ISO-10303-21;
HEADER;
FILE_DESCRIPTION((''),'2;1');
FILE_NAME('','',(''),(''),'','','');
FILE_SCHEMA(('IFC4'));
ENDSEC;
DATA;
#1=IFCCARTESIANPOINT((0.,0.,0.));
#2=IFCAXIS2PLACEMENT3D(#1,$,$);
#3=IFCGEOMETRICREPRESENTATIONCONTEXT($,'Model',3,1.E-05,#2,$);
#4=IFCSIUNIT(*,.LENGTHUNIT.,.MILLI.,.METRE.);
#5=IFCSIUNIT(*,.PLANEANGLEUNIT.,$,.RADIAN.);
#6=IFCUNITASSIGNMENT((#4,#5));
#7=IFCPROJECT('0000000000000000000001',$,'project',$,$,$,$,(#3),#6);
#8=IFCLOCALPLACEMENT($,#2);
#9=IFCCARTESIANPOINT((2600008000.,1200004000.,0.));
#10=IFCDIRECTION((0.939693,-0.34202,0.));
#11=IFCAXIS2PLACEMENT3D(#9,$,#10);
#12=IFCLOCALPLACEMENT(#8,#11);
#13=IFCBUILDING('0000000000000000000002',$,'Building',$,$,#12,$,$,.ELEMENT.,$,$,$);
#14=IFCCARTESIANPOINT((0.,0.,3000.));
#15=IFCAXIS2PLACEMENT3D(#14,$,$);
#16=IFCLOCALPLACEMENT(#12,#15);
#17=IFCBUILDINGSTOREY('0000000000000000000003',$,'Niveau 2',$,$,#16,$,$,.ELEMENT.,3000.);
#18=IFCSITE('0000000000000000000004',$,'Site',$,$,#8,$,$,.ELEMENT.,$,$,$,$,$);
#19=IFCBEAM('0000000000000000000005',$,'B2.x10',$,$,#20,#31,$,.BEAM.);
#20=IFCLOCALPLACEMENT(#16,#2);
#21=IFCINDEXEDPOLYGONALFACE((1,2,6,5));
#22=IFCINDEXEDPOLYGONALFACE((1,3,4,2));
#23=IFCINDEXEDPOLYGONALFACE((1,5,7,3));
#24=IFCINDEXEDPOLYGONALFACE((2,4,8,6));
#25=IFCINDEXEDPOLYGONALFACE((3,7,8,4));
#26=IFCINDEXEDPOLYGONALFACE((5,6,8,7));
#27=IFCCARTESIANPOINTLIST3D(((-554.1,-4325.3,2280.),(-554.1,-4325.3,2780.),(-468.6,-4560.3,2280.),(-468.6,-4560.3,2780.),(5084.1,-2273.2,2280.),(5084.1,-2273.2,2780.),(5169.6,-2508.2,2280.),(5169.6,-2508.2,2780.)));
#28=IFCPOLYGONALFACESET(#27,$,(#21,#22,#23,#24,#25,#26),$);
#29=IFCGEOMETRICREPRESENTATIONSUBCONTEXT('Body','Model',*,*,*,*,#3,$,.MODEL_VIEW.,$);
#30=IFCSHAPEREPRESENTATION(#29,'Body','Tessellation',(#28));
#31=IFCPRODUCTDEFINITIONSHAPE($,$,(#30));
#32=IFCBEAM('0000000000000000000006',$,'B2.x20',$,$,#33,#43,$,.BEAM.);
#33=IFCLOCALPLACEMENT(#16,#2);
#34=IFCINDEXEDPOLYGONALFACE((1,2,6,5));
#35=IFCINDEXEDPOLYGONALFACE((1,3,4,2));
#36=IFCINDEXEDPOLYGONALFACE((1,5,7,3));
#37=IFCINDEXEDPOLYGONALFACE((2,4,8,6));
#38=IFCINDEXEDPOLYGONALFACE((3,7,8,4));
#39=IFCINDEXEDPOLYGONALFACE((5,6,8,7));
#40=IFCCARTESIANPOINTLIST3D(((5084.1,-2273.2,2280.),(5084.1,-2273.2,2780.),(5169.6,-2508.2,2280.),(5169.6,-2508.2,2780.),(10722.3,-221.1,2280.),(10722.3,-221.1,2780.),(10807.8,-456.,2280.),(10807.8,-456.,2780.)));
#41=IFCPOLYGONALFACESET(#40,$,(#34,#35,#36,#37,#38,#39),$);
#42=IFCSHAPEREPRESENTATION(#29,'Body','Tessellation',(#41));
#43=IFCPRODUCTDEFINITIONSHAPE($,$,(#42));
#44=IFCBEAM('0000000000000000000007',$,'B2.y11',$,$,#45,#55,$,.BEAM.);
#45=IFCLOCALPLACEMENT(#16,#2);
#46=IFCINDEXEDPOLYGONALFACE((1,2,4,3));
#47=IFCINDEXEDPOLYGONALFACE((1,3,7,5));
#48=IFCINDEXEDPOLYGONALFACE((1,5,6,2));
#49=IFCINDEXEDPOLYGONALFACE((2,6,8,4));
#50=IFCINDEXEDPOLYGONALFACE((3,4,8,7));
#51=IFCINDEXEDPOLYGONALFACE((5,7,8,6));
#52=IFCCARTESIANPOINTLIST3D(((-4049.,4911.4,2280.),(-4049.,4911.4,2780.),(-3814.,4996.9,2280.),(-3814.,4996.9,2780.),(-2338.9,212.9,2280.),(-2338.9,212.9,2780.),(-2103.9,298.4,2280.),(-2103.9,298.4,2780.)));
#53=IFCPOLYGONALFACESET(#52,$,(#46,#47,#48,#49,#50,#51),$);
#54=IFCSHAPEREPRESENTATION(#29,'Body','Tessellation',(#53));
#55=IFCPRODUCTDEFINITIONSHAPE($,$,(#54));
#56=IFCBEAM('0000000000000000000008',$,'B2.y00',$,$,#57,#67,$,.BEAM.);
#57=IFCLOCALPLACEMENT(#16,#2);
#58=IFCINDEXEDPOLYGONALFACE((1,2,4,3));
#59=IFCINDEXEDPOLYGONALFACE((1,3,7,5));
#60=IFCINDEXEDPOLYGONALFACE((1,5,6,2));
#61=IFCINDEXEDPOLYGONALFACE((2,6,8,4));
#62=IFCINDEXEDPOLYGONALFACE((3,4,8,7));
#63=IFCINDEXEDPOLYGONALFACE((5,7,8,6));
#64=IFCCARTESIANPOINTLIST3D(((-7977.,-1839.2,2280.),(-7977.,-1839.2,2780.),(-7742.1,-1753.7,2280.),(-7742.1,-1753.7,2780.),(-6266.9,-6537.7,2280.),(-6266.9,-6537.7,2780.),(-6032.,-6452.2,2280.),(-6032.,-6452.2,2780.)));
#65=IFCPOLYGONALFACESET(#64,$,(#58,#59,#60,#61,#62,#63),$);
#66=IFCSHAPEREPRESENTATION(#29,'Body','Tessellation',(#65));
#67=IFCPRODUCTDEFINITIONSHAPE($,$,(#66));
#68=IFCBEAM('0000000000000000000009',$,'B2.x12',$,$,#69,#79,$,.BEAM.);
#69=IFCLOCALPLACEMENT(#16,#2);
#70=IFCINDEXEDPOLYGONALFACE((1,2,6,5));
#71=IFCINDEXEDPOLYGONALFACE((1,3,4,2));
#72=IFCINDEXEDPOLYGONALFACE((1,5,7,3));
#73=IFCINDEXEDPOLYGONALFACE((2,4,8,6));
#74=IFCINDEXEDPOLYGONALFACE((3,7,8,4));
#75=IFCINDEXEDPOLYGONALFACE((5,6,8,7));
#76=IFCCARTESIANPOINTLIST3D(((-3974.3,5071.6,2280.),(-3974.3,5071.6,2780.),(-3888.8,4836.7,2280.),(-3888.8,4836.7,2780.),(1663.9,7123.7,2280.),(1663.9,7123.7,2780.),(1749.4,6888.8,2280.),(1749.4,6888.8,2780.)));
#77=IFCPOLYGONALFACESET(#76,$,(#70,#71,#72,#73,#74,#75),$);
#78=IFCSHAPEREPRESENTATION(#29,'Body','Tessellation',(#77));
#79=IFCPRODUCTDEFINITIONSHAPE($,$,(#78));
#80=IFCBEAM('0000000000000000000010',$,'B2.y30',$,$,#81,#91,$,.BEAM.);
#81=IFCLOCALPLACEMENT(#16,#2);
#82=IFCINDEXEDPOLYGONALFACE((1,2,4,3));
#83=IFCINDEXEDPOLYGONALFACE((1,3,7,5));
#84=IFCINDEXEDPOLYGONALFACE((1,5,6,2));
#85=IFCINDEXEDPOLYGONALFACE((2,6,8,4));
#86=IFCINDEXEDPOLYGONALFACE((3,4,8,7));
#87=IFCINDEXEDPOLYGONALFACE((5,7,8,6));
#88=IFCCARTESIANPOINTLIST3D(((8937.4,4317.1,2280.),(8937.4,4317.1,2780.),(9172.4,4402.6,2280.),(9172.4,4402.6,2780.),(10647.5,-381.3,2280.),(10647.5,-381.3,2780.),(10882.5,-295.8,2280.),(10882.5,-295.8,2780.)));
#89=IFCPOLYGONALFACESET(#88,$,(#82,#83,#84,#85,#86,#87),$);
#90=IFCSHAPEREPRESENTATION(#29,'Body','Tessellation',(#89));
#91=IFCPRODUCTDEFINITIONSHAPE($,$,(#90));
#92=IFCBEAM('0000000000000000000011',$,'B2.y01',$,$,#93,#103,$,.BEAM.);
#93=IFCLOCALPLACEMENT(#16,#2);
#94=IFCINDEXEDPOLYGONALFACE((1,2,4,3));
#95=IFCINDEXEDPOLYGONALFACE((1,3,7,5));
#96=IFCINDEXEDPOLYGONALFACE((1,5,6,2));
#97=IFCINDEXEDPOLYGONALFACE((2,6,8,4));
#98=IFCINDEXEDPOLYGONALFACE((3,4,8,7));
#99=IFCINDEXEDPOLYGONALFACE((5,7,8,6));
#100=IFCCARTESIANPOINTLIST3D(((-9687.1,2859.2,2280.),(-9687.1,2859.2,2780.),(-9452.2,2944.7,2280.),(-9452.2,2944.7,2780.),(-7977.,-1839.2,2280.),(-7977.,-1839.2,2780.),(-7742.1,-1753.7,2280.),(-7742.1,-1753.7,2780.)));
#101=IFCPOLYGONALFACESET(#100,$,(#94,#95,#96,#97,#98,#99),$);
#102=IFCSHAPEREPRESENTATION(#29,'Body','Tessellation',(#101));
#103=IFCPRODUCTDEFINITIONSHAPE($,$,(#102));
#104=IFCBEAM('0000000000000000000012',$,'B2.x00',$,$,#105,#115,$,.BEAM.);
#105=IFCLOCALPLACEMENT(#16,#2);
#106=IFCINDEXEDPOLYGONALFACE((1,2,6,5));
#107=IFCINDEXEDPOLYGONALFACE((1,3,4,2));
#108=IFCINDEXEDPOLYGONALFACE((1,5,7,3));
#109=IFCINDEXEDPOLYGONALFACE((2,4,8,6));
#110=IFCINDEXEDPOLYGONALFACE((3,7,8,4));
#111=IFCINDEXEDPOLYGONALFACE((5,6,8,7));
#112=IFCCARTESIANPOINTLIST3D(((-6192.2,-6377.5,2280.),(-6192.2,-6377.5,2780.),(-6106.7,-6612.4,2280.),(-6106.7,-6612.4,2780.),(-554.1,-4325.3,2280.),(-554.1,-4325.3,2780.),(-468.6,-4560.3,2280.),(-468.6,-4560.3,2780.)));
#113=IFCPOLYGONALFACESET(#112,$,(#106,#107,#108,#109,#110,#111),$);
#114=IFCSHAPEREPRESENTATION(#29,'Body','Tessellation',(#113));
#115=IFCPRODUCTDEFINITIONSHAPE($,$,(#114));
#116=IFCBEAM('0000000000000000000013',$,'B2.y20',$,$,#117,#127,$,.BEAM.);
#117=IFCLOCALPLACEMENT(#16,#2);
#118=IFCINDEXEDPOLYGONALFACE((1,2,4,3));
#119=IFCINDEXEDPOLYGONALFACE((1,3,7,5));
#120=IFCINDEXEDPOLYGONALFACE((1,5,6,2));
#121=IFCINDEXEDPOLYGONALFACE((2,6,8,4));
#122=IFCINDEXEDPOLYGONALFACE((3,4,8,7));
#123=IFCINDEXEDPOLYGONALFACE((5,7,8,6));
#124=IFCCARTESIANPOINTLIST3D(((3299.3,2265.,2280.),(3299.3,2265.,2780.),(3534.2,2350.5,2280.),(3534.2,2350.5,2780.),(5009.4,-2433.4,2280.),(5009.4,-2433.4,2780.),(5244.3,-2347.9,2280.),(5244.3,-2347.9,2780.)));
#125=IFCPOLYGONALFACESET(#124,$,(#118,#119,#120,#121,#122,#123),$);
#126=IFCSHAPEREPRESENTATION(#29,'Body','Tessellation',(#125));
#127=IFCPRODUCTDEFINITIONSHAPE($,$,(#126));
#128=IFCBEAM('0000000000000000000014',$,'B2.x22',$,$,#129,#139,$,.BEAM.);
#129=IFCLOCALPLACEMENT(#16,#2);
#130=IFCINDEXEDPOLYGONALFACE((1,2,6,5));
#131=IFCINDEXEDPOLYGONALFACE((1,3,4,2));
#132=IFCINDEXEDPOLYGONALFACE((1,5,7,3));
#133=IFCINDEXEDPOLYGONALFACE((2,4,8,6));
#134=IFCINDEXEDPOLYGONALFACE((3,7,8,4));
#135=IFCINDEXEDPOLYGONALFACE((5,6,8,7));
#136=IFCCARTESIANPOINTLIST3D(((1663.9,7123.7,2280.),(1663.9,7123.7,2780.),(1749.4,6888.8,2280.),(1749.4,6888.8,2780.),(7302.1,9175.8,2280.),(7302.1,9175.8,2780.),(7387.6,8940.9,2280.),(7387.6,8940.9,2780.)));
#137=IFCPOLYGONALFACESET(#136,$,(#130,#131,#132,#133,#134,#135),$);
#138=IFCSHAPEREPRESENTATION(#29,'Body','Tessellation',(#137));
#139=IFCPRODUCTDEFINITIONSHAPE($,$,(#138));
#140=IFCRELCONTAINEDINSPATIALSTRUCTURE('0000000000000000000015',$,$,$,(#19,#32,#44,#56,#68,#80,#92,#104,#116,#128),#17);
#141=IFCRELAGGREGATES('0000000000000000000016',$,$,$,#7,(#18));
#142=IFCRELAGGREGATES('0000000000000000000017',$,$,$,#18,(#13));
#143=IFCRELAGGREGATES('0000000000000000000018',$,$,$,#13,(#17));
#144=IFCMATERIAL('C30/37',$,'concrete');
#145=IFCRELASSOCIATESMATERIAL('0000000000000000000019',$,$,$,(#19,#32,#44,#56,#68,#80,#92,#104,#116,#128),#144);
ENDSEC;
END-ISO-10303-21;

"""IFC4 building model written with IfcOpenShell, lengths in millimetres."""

from ifc_helpers import new_model, si_unit, frame, origin, place, context, subcontext, project, spatial, rectangle, extrude, material, element, save


model = new_model("IFC4")

# Units and contexts
model_context = context("Model", 3, precision=1e-05, world=origin())
body_context = subcontext(model_context, "Body", "Model", "MODEL_VIEW")
ifc_project = project(units=[si_unit("LENGTHUNIT", "METRE", prefix="MILLI"), si_unit("PLANEANGLEUNIT", "RADIAN")], contexts=[model_context])

# Site, building, storey
site_placement = place(None, origin())
site = spatial("IfcSite", under=ifc_project, at=site_placement, Name="Site", CompositionType="ELEMENT")
building_placement = place(site_placement, frame((2600008000.0, 1200004000.0, 0.0), x_axis=(0.939693, -0.34202, 0.0)))
building = spatial("IfcBuilding", under=site, at=building_placement, Name="Building", CompositionType="ELEMENT")
storey_placement = place(building_placement, frame((0.0, 0.0, 3000.0)))
storey = spatial("IfcBuildingStorey", under=building, at=storey_placement, Name="Niveau 2", CompositionType="ELEMENT", Elevation=3000.0)

# Shared definitions
ifc_material = material(Name="C30/37", Category="concrete")

# Beams
for number, where, z_axis, x_axis, name in (
    (1, (-511.3, -4442.8, 2530.0), (0.939693, 0.34202, 0.0), (-0.34202, 0.939693, 0.0), "B2.x10"),
    (2, (5126.9, -2390.7, 2530.0), (0.939693, 0.34202, 0.0), (-0.34202, 0.939693, 0.0), "B2.x20"),
):
    element("IfcBeam", number, at=place(storey_placement, frame(where, z_axis=z_axis, x_axis=x_axis)), inside=storey, material=ifc_material, Name=name, PredefinedType="BEAM", context=body_context, shape_type="SweptSolid", body=[
        extrude(rectangle(XDim=250.0, YDim=500.0), origin(), (0.0, 0.0, 1.0), 6000.0),
    ])
for number, where, z_axis, x_axis, name in (
    (3, (-2221.4, 255.7, 2530.0), (-0.34202, 0.939693, 0.0), (-0.939693, -0.34202, 0.0), "B2.y11"),
    (4, (-6149.5, -6494.9, 2530.0), (-0.34202, 0.939693, 0.0), (-0.939693, -0.34202, 0.0), "B2.y00"),
):
    element("IfcBeam", number, at=place(storey_placement, frame(where, z_axis=z_axis, x_axis=x_axis)), inside=storey, material=ifc_material, Name=name, PredefinedType="BEAM", context=body_context, shape_type="SweptSolid", body=[
        extrude(rectangle(XDim=250.0, YDim=500.0), origin(), (0.0, 0.0, 1.0), 5000.0),
    ])
beam_1_placement = place(storey_placement, frame((-3931.5, 4954.1, 2530.0), z_axis=(0.939693, 0.34202, 0.0), x_axis=(-0.34202, 0.939693, 0.0)))
element("IfcBeam", 5, at=beam_1_placement, inside=storey, material=ifc_material, Name="B2.x12", PredefinedType="BEAM", context=body_context, shape_type="SweptSolid", body=[
    extrude(rectangle(XDim=250.0, YDim=500.0), origin(), (0.0, 0.0, 1.0), 6000.0),
])
for number, where, z_axis, x_axis, name in (
    (6, (10765.0, -338.6, 2530.0), (-0.34202, 0.939693, 0.0), (-0.939693, -0.34202, 0.0), "B2.y30"),
    (7, (-7859.6, -1796.5, 2530.0), (-0.34202, 0.939693, 0.0), (-0.939693, -0.34202, 0.0), "B2.y01"),
):
    element("IfcBeam", number, at=place(storey_placement, frame(where, z_axis=z_axis, x_axis=x_axis)), inside=storey, material=ifc_material, Name=name, PredefinedType="BEAM", context=body_context, shape_type="SweptSolid", body=[
        extrude(rectangle(XDim=250.0, YDim=500.0), origin(), (0.0, 0.0, 1.0), 5000.0),
    ])
beam_2_placement = place(storey_placement, frame((-6149.5, -6494.9, 2530.0), z_axis=(0.939693, 0.34202, 0.0), x_axis=(-0.34202, 0.939693, 0.0)))
element("IfcBeam", 8, at=beam_2_placement, inside=storey, material=ifc_material, Name="B2.x00", PredefinedType="BEAM", context=body_context, shape_type="SweptSolid", body=[
    extrude(rectangle(XDim=250.0, YDim=500.0), origin(), (0.0, 0.0, 1.0), 6000.0),
])
beam_3_placement = place(storey_placement, frame((5126.9, -2390.7, 2530.0), z_axis=(-0.34202, 0.939693, 0.0), x_axis=(-0.939693, -0.34202, 0.0)))
element("IfcBeam", 9, at=beam_3_placement, inside=storey, material=ifc_material, Name="B2.y20", PredefinedType="BEAM", context=body_context, shape_type="SweptSolid", body=[
    extrude(rectangle(XDim=250.0, YDim=500.0), origin(), (0.0, 0.0, 1.0), 5000.0),
])
beam_4_placement = place(storey_placement, frame((1706.6, 7006.2, 2530.0), z_axis=(0.939693, 0.34202, 0.0), x_axis=(-0.34202, 0.939693, 0.0)))
element("IfcBeam", 10, at=beam_4_placement, inside=storey, material=ifc_material, Name="B2.x22", PredefinedType="BEAM", context=body_context, shape_type="SweptSolid", body=[
    extrude(rectangle(XDim=250.0, YDim=500.0), origin(), (0.0, 0.0, 1.0), 6000.0),
])

save(model, "model.ifc")
